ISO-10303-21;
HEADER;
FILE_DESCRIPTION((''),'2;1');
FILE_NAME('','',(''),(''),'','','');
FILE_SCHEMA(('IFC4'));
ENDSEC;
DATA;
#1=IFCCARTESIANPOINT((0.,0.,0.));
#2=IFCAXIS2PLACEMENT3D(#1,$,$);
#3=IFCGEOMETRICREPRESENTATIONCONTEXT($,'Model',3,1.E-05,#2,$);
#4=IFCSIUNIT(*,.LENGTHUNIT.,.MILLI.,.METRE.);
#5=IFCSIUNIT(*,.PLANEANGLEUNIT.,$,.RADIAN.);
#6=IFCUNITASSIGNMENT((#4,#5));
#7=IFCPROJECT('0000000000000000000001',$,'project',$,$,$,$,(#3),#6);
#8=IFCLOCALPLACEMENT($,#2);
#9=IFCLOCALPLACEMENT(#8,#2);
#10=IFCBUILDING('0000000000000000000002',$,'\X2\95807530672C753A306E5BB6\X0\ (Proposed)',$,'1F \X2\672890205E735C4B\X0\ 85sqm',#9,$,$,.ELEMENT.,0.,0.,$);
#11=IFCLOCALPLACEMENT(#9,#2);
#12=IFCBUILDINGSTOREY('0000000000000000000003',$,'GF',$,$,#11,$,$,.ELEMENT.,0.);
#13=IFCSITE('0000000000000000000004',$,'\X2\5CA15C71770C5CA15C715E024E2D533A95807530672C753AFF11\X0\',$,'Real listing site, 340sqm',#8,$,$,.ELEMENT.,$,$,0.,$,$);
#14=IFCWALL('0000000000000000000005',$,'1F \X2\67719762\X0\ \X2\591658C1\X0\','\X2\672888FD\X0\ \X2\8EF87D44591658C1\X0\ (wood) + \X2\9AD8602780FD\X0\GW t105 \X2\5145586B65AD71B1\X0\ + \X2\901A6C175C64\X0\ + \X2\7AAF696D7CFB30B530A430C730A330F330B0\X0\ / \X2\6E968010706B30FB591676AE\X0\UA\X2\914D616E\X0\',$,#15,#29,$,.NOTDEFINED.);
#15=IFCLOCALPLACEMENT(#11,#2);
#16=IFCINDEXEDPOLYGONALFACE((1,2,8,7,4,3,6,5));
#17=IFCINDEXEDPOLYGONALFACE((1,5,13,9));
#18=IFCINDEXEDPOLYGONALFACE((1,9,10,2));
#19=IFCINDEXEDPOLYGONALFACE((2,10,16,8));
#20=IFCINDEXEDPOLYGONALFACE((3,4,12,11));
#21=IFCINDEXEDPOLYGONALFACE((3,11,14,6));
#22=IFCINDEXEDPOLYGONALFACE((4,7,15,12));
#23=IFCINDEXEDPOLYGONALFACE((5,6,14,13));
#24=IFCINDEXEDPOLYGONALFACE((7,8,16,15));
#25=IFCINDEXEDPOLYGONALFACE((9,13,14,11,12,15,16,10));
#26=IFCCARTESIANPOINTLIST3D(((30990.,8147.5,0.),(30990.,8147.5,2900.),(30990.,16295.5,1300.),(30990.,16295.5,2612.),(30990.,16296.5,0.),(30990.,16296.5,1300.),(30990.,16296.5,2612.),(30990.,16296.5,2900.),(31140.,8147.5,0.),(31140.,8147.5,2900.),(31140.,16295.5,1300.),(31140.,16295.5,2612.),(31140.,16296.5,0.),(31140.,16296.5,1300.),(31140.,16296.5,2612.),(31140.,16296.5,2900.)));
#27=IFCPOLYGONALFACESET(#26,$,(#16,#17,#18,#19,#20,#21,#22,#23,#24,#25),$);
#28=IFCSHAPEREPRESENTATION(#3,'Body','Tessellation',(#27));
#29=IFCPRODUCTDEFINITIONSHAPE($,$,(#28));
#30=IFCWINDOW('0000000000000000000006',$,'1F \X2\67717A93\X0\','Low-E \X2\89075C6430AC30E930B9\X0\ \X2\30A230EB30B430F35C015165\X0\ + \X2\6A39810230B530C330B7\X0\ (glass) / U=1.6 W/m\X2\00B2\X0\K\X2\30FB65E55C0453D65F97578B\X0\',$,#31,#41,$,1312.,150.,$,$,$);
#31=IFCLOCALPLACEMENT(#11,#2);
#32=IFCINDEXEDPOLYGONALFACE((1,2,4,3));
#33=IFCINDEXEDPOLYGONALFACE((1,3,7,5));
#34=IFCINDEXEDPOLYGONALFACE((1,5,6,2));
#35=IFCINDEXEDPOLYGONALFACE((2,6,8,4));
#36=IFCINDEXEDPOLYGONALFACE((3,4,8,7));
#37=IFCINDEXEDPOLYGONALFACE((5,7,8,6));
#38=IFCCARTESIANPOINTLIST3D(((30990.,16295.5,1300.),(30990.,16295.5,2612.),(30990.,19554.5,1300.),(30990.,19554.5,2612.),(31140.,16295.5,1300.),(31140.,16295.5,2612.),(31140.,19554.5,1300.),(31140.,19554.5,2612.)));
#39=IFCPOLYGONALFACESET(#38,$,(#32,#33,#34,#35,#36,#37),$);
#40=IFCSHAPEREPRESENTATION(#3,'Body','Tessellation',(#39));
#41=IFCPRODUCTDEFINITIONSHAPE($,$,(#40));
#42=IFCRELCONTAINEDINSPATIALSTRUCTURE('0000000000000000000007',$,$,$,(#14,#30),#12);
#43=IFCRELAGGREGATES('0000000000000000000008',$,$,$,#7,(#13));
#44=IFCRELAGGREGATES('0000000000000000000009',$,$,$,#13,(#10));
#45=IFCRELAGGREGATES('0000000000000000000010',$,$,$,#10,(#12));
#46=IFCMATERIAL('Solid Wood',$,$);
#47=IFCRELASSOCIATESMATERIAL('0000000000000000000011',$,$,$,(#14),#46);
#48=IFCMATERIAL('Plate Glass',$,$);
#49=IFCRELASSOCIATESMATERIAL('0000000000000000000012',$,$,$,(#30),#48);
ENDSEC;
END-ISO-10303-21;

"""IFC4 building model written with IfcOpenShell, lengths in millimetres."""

from ifc_helpers import new_model, si_unit, frame, frame_2d, origin, place, context, project, spatial, rectangle, extrude, material, element, fill, save


model = new_model("IFC4")

# Units and contexts
model_context = context("Model", 3, precision=1e-05, world=origin())
ifc_project = project(units=[si_unit("LENGTHUNIT", "METRE", prefix="MILLI"), si_unit("PLANEANGLEUNIT", "RADIAN")], contexts=[model_context])

# Site, building, storey
site_placement = place(None, origin())
site = spatial("IfcSite", under=ifc_project, at=site_placement, Name="岡山県岡山市中区門田本町１", ObjectType="Real listing site, 340sqm", CompositionType="ELEMENT", RefElevation=0.0)
building_placement = place(site_placement, origin())
building = spatial("IfcBuilding", under=site, at=building_placement, Name="門田本町の家 (Proposed)", ObjectType="1F 木造平屋 85sqm", CompositionType="ELEMENT", ElevationOfRefHeight=0.0, ElevationOfTerrain=0.0)
storey_placement = place(building_placement, origin())
storey = spatial("IfcBuildingStorey", under=building, at=storey_placement, Name="GF", CompositionType="ELEMENT", Elevation=0.0)

# Wall, opening, window
ifc_material_1 = material(Name="Solid Wood")
wall_1_placement = place(storey_placement, frame((15495.0, 4074.0, 0.0)))
wall_1 = element("IfcWall", 1, at=wall_1_placement, inside=storey, material=ifc_material_1, Name="1F 東面 外壁", Description="木製 軸組外壁 (wood) + 高性能GW t105 充填断熱 + 通気層 + 窯業系サイディング / 準耐火・外皮UA配慮", PredefinedType="NOTDEFINED", context=model_context, shape_type="SweptSolid", body=[
    extrude(rectangle(XDim=150.0, YDim=8149.0, at=frame_2d((75.0, 4074.0))), frame((15495.0, 4074.0, 0.0)), (0.0, 0.0, 1.0), 2900.0),
])
opening_placement = place(storey_placement, frame((15495.0, 8148.0, 650.0)))
opening = element("IfcOpeningElement", 2, at=opening_placement, cuts=wall_1, PredefinedType="NOTDEFINED", context=model_context, shape_type="SweptSolid", body=[
    extrude(rectangle(XDim=150.0, YDim=3259.0, at=frame_2d((75.0, 1629.0))), frame((15495.0, 8148.0, 650.0)), (0.0, 0.0, 1.0), 1312.0),
])
ifc_material_2 = material(Name="Plate Glass")
window_1_placement = place(storey_placement, frame((15495.0, 8148.0, 650.0)))
window_1 = element("IfcWindow", 3, at=window_1_placement, inside=storey, material=ifc_material_2, Name="1F 東窓", Description="Low-E 複層ガラス アルゴン封入 + 樹脂サッシ (glass) / U=1.6 W/m²K・日射取得型", OverallHeight=1312.0, OverallWidth=150.0, context=model_context, shape_type="SweptSolid", body=[
    extrude(rectangle(XDim=150.0, YDim=3259.0, at=frame_2d((75.0, 1629.0))), frame((15495.0, 8148.0, 650.0)), (0.0, 0.0, 1.0), 1312.0),
])
fill(opening, window_1)

save(model, "model.ifc")
